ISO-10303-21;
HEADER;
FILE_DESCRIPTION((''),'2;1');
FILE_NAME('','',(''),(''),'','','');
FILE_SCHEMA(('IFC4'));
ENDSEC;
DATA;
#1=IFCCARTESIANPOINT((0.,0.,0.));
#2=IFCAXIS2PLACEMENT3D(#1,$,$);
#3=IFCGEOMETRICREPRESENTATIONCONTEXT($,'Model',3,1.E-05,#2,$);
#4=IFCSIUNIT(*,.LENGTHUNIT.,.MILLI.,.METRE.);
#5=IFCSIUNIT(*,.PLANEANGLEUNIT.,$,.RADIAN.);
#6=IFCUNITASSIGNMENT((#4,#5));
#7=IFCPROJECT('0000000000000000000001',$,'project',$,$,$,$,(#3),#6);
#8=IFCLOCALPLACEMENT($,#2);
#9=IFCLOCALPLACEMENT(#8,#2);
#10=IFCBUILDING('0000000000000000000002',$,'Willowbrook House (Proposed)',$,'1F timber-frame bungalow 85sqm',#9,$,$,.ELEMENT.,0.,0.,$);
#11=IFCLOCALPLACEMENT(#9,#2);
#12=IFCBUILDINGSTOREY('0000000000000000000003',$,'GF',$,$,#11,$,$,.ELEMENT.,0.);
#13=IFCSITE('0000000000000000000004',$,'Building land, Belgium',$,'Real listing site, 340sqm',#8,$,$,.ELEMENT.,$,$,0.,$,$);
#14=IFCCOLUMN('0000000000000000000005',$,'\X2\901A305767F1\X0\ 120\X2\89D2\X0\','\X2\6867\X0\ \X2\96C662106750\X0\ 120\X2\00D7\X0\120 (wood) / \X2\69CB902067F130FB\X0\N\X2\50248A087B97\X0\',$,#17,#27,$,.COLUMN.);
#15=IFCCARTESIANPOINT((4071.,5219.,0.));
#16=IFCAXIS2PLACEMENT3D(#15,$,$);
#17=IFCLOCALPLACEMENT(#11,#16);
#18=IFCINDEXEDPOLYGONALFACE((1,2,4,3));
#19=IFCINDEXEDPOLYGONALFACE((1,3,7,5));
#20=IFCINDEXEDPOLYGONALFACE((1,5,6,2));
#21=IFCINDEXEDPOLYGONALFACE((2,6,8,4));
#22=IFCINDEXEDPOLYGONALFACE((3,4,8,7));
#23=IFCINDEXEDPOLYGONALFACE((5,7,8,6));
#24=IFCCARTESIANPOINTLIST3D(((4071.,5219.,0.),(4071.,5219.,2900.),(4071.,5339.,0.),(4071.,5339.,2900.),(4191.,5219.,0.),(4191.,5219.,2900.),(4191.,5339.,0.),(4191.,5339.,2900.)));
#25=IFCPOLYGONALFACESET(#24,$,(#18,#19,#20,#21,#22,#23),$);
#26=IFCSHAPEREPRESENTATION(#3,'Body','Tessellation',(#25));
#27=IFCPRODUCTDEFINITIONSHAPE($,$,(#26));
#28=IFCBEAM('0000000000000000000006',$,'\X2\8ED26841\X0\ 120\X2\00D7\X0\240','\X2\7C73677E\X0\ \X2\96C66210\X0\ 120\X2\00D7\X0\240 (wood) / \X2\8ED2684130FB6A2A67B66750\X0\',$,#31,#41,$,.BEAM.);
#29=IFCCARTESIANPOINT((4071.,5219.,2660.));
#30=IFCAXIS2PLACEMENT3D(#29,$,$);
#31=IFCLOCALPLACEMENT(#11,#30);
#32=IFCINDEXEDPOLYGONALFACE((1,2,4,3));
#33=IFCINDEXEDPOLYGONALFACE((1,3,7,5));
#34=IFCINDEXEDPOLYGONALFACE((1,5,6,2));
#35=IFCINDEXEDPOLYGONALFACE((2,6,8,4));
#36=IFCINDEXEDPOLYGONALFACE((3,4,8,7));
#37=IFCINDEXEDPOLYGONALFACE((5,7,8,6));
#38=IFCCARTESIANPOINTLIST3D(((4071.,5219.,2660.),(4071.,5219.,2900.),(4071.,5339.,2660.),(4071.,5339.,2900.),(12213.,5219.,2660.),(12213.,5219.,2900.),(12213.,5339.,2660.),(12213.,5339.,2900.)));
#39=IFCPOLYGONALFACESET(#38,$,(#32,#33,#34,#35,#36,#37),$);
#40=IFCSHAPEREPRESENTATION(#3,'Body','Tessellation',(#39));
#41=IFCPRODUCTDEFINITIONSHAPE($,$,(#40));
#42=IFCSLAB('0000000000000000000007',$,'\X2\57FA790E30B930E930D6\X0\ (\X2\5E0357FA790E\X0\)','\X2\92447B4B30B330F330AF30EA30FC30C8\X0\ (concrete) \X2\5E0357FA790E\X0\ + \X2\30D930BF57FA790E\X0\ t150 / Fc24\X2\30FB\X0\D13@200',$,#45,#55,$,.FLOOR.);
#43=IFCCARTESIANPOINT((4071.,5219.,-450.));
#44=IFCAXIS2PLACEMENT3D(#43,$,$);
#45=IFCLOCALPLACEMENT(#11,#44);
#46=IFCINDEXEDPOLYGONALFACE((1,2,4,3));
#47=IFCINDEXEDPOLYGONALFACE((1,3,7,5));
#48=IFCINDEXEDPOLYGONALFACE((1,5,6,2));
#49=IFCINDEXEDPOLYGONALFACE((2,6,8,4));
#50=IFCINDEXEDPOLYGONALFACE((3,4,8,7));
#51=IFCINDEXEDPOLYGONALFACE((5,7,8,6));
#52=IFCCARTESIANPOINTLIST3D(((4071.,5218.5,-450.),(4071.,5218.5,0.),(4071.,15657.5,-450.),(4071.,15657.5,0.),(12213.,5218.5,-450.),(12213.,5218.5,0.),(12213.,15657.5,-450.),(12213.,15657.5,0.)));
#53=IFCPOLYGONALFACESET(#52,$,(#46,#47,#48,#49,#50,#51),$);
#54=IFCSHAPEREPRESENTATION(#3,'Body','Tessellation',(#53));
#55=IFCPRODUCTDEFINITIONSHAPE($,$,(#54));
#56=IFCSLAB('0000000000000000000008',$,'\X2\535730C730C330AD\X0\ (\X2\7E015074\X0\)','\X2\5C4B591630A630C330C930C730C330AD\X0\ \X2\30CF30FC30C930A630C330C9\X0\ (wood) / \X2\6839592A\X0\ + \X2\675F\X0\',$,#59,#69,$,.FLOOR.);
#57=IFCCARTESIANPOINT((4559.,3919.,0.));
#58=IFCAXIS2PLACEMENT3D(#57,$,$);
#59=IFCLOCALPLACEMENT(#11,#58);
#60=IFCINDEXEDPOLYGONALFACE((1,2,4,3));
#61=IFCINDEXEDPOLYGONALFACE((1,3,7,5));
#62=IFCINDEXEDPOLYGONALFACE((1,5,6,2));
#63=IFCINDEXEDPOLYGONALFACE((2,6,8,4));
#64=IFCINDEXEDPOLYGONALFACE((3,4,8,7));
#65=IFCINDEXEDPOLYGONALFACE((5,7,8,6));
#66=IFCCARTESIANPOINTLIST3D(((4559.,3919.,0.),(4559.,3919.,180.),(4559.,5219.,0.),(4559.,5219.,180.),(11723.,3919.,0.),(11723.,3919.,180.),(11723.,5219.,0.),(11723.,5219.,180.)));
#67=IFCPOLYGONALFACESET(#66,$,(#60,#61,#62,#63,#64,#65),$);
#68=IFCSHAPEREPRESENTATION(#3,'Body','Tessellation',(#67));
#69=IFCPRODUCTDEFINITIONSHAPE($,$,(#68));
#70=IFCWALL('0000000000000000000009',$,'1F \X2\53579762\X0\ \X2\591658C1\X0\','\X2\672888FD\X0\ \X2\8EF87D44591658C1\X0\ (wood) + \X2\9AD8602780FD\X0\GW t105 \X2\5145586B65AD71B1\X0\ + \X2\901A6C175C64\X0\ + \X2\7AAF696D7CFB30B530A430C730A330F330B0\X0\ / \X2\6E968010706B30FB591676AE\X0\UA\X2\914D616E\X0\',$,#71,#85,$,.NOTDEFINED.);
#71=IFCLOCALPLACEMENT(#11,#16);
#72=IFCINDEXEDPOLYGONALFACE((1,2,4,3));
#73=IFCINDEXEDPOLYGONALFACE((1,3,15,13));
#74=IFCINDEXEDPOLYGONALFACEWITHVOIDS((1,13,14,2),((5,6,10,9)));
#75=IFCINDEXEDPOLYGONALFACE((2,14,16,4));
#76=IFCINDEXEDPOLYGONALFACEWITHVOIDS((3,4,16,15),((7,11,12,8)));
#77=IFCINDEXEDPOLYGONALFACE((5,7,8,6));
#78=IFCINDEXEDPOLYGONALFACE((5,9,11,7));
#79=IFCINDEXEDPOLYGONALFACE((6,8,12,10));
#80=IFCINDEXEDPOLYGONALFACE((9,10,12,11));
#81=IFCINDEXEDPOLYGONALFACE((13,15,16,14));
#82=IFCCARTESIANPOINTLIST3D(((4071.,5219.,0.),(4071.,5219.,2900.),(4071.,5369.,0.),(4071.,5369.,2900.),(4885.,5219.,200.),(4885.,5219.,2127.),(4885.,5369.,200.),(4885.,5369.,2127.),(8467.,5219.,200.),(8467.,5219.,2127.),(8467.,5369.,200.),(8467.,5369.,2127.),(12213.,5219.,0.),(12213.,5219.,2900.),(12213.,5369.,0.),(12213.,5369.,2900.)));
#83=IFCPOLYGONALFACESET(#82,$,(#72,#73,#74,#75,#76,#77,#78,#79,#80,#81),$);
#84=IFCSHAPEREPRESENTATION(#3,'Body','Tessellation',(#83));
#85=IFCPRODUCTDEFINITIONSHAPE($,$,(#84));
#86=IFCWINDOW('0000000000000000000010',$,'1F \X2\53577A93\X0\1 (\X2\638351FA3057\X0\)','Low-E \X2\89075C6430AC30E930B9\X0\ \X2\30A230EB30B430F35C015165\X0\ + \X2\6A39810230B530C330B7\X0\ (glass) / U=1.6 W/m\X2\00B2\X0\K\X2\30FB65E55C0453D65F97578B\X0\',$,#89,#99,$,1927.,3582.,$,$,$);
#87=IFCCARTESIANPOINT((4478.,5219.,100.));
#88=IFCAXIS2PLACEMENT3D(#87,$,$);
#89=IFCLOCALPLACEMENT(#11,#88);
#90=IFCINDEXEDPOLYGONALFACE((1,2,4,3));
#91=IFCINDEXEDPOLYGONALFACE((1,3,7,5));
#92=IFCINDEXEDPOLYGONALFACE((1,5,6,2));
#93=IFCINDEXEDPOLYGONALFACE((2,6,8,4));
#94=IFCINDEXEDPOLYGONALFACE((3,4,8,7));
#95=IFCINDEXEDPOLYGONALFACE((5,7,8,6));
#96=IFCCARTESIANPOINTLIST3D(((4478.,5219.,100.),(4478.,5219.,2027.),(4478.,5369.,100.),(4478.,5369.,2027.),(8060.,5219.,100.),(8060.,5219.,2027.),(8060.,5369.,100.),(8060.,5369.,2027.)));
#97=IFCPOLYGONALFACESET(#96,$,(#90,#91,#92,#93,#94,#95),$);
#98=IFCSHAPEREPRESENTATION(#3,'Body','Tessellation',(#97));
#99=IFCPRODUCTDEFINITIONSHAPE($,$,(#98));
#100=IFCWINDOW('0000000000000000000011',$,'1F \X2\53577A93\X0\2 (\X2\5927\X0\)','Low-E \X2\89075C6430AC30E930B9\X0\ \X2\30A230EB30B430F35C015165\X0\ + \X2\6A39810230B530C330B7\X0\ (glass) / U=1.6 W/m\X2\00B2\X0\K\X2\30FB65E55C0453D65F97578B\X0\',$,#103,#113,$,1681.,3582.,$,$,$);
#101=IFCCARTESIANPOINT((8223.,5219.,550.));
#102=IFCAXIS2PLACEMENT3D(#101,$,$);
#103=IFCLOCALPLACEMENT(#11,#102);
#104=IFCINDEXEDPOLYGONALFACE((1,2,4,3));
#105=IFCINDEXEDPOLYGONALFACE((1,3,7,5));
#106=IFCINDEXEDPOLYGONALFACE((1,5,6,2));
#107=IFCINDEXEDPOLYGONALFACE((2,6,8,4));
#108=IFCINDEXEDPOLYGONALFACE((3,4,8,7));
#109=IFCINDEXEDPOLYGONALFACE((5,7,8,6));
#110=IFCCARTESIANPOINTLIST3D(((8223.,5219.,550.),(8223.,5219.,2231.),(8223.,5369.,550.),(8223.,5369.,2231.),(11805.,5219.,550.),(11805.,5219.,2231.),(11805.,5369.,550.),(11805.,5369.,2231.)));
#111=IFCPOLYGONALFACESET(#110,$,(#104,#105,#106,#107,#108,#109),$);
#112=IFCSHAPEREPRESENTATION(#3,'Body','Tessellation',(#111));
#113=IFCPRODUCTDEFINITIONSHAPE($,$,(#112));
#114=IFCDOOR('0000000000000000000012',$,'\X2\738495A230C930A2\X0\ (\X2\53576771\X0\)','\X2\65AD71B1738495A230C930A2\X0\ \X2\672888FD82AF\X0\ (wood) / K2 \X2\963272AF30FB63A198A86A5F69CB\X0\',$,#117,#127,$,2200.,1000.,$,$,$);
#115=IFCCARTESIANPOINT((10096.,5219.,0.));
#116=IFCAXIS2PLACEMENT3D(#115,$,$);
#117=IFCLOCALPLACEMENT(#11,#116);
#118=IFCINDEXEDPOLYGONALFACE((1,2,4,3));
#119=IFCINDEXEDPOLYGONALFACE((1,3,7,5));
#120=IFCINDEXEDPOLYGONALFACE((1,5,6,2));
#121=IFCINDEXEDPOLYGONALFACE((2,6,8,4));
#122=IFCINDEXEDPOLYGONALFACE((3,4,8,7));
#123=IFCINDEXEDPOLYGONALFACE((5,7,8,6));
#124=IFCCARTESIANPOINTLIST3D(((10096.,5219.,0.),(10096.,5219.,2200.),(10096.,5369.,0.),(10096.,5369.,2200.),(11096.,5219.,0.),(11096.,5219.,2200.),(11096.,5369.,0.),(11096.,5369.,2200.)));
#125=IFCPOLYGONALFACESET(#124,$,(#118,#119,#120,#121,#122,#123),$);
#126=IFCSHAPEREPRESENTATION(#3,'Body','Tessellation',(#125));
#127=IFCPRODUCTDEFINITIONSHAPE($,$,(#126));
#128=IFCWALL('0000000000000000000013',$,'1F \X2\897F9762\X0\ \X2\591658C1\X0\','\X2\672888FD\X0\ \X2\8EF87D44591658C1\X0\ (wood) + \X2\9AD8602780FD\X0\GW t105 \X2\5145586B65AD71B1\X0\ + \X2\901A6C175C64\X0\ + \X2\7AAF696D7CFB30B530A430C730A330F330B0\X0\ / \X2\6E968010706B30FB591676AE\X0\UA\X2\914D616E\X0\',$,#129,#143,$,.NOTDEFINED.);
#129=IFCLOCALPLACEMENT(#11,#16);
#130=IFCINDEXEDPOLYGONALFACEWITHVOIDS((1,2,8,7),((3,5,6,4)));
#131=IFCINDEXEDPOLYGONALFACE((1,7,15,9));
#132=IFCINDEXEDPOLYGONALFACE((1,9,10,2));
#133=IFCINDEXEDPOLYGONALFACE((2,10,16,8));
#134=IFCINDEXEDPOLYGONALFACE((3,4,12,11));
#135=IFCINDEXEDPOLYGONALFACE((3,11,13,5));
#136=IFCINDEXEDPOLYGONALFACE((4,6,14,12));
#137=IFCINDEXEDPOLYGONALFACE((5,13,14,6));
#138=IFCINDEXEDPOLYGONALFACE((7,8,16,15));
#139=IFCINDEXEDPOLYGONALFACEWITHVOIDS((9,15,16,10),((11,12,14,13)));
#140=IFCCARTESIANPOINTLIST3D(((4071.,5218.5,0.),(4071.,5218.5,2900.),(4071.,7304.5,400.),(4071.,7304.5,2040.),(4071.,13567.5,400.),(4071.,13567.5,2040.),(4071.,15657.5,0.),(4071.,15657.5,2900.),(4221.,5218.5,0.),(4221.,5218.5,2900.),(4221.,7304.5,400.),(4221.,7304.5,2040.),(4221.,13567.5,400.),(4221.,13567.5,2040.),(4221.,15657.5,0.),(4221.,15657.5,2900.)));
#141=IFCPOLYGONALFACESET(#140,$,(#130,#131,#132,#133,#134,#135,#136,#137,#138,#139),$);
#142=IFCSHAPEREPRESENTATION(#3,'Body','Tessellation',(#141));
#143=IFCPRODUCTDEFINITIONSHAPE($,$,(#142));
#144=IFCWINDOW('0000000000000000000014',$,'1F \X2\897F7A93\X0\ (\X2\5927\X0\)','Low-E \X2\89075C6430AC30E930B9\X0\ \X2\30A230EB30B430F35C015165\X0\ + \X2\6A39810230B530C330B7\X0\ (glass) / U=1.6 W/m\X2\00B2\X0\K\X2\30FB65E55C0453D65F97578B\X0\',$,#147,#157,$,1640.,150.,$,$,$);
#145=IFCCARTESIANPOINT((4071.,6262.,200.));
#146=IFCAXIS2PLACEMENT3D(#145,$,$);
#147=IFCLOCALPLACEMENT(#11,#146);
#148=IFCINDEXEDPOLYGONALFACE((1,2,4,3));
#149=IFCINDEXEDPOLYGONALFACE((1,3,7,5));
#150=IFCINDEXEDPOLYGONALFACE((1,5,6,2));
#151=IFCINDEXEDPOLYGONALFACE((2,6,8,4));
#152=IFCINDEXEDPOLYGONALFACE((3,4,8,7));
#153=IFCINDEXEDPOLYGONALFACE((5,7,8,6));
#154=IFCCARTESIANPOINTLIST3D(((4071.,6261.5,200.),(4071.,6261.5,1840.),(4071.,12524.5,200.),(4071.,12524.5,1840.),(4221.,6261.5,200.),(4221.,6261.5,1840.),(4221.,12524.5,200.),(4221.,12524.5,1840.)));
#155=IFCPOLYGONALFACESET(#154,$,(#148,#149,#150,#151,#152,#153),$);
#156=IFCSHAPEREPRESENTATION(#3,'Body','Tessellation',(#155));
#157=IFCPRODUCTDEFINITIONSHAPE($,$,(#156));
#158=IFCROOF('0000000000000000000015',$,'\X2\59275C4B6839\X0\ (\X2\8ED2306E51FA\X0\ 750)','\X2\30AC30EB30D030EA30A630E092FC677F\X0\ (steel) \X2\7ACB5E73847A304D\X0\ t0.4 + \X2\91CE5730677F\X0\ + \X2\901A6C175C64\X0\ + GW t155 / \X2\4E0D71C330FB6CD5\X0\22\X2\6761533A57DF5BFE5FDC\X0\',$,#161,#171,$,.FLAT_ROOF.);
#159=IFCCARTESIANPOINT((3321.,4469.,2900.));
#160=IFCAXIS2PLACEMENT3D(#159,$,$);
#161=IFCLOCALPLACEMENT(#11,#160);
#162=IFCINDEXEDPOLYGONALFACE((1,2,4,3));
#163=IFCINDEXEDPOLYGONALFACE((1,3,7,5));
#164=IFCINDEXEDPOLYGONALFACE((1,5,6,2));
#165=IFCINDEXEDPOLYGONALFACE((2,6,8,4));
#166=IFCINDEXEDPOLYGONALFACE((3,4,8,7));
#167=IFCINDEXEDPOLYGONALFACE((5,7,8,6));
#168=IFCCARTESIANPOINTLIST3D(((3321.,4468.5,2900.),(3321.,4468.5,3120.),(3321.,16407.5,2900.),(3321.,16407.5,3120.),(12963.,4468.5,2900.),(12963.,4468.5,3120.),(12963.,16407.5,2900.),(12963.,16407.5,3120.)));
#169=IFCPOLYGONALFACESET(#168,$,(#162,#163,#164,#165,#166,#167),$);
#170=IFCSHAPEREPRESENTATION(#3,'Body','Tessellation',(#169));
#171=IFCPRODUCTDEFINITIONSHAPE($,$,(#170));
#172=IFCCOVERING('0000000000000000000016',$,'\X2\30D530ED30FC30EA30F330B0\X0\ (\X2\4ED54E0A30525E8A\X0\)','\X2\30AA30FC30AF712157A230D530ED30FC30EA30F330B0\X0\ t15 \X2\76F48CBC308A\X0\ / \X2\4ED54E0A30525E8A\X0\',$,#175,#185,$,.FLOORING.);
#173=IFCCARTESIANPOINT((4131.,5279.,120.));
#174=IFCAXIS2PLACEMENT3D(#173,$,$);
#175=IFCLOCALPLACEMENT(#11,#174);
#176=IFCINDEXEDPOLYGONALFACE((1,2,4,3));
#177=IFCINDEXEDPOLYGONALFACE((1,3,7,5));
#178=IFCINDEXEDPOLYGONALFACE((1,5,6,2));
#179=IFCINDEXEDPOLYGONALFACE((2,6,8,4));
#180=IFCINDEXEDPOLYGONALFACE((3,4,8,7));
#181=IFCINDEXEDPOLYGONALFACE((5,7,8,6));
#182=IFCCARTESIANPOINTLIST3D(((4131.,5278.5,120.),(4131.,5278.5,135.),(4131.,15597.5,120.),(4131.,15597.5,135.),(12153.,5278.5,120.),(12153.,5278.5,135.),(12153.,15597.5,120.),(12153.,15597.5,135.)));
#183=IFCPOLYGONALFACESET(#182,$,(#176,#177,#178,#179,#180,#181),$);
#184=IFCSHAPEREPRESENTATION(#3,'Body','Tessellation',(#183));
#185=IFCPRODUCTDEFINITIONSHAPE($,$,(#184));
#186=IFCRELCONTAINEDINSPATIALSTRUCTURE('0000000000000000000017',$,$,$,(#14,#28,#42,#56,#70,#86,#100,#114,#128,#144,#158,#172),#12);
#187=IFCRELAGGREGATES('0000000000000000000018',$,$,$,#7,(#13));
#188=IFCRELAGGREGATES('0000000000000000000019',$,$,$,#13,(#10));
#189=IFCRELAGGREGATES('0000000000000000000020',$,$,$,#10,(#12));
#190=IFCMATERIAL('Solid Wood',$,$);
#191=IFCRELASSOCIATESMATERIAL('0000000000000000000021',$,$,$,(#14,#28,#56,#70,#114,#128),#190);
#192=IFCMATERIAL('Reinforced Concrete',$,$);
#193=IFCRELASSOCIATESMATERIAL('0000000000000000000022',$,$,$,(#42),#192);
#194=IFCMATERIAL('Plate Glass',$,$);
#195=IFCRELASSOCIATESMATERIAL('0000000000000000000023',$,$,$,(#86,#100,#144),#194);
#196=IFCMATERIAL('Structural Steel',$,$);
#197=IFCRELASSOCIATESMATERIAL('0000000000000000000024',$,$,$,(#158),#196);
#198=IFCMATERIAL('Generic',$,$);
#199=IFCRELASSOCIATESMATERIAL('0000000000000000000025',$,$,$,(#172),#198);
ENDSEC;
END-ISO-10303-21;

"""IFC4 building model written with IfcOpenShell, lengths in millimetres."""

from ifc_helpers import new_model, si_unit, frame, frame_2d, origin, place, context, project, spatial, rectangle, extrude, material, element, fill, save


model = new_model("IFC4")

# Units and contexts
model_context = context("Model", 3, precision=1e-05, world=origin())
ifc_project = project(units=[si_unit("LENGTHUNIT", "METRE", prefix="MILLI"), si_unit("PLANEANGLEUNIT", "RADIAN")], contexts=[model_context])

# Site, building, storey
site_placement = place(None, origin())
site = spatial("IfcSite", under=ifc_project, at=site_placement, Name="Building land, Belgium", ObjectType="Real listing site, 340sqm", CompositionType="ELEMENT", RefElevation=0.0)
building_placement = place(site_placement, origin())
building = spatial("IfcBuilding", under=site, at=building_placement, Name="Willowbrook House (Proposed)", ObjectType="1F timber-frame bungalow 85sqm", CompositionType="ELEMENT", ElevationOfRefHeight=0.0, ElevationOfTerrain=0.0)
storey_placement = place(building_placement, origin())
storey = spatial("IfcBuildingStorey", under=building, at=storey_placement, Name="GF", CompositionType="ELEMENT", Elevation=0.0)

# Column
ifc_material_1 = material(Name="Solid Wood")
column_1_placement = place(storey_placement, frame((4071.0, 5219.0, 0.0)))
element("IfcColumn", 1, at=column_1_placement, inside=storey, material=ifc_material_1, Name="通し柱 120角", Description="桧 集成材 120×120 (wood) / 構造柱・N値計算", PredefinedType="COLUMN", context=model_context, shape_type="SweptSolid", body=[
    extrude(rectangle(XDim=120.0, YDim=120.0, at=frame_2d((60.0, 60.0))), frame((4071.0, 5219.0, 0.0)), (0.0, 0.0, 1.0), 2900.0),
])

# Beam
beam_1_placement = place(storey_placement, frame((4071.0, 5219.0, 2660.0)))
element("IfcBeam", 2, at=beam_1_placement, inside=storey, material=ifc_material_1, Name="軒桁 120×240", Description="米松 集成 120×240 (wood) / 軒桁・横架材", PredefinedType="BEAM", context=model_context, shape_type="SweptSolid", body=[
    extrude(rectangle(XDim=8142.0, YDim=120.0, at=frame_2d((4071.0, 60.0))), frame((4071.0, 5219.0, 2660.0)), (0.0, 0.0, 1.0), 240.0),
])

# Slabs
ifc_material_2 = material(Name="Reinforced Concrete")
slab_1_placement = place(storey_placement, frame((4071.0, 5219.0, -450.0)))
element("IfcSlab", 3, at=slab_1_placement, inside=storey, material=ifc_material_2, Name="基礎スラブ (布基礎)", Description="鉄筋コンクリート (concrete) 布基礎 + ベタ基礎 t150 / Fc24・D13@200", PredefinedType="FLOOR", context=model_context, shape_type="SweptSolid", body=[
    extrude(rectangle(XDim=8142.0, YDim=10439.0, at=frame_2d((4071.0, 5219.0))), frame((4071.0, 5219.0, -450.0)), (0.0, 0.0, 1.0), 450.0),
])
slab_2_placement = place(storey_placement, frame((4559.0, 3919.0, 0.0)))
element("IfcSlab", 4, at=slab_2_placement, inside=storey, material=ifc_material_1, Name="南デッキ (縁側)", Description="屋外ウッドデッキ ハードウッド (wood) / 根太 + 束", PredefinedType="FLOOR", context=model_context, shape_type="SweptSolid", body=[
    extrude(rectangle(XDim=7164.0, YDim=1300.0, at=frame_2d((3582.0, 650.0))), frame((4559.0, 3919.0, 0.0)), (0.0, 0.0, 1.0), 180.0),
])

# Wall, openings, windows, door
wall_1_placement = place(storey_placement, frame((4071.0, 5219.0, 0.0)))
wall_1 = element("IfcWall", 5, at=wall_1_placement, inside=storey, material=ifc_material_1, Name="1F 南面 外壁", Description="木製 軸組外壁 (wood) + 高性能GW t105 充填断熱 + 通気層 + 窯業系サイディング / 準耐火・外皮UA配慮", PredefinedType="NOTDEFINED", context=model_context, shape_type="SweptSolid", body=[
    extrude(rectangle(XDim=8142.0, YDim=150.0, at=frame_2d((4071.0, 75.0))), frame((4071.0, 5219.0, 0.0)), (0.0, 0.0, 1.0), 2900.0),
])
opening_1_placement = place(storey_placement, frame((4478.0, 5219.0, 100.0)))
opening_1 = element("IfcOpeningElement", 6, at=opening_1_placement, cuts=wall_1, PredefinedType="NOTDEFINED", context=model_context, shape_type="SweptSolid", body=[
    extrude(rectangle(XDim=3582.0, YDim=150.0, at=frame_2d((1791.0, 75.0))), frame((4478.0, 5219.0, 100.0)), (0.0, 0.0, 1.0), 1927.0),
])
opening_2_placement = place(storey_placement, frame((8223.0, 5219.0, 550.0)))
opening_2 = element("IfcOpeningElement", 7, at=opening_2_placement, cuts=wall_1, PredefinedType="NOTDEFINED", context=model_context, shape_type="SweptSolid", body=[
    extrude(rectangle(XDim=3582.0, YDim=150.0, at=frame_2d((1791.0, 75.0))), frame((8223.0, 5219.0, 550.0)), (0.0, 0.0, 1.0), 1681.0),
])
opening_3_placement = place(storey_placement, frame((10096.0, 5219.0, 0.0)))
opening_3 = element("IfcOpeningElement", 8, at=opening_3_placement, cuts=wall_1, PredefinedType="NOTDEFINED", context=model_context, shape_type="SweptSolid", body=[
    extrude(rectangle(XDim=1000.0, YDim=150.0, at=frame_2d((500.0, 75.0))), frame((10096.0, 5219.0, 0.0)), (0.0, 0.0, 1.0), 2200.0),
])
ifc_material_3 = material(Name="Plate Glass")
window_1_placement = place(storey_placement, frame((4478.0, 5219.0, 100.0)))
window_1 = element("IfcWindow", 9, at=window_1_placement, inside=storey, material=ifc_material_3, Name="1F 南窓1 (掃出し)", Description="Low-E 複層ガラス アルゴン封入 + 樹脂サッシ (glass) / U=1.6 W/m²K・日射取得型", OverallHeight=1927.0, OverallWidth=3582.0, context=model_context, shape_type="SweptSolid", body=[
    extrude(rectangle(XDim=3582.0, YDim=150.0, at=frame_2d((1791.0, 75.0))), frame((4478.0, 5219.0, 100.0)), (0.0, 0.0, 1.0), 1927.0),
])
fill(opening_1, window_1)
window_2_placement = place(storey_placement, frame((8223.0, 5219.0, 550.0)))
window_2 = element("IfcWindow", 10, at=window_2_placement, inside=storey, material=ifc_material_3, Name="1F 南窓2 (大)", Description="Low-E 複層ガラス アルゴン封入 + 樹脂サッシ (glass) / U=1.6 W/m²K・日射取得型", OverallHeight=1681.0, OverallWidth=3582.0, context=model_context, shape_type="SweptSolid", body=[
    extrude(rectangle(XDim=3582.0, YDim=150.0, at=frame_2d((1791.0, 75.0))), frame((8223.0, 5219.0, 550.0)), (0.0, 0.0, 1.0), 1681.0),
])
fill(opening_2, window_2)
door_placement = place(storey_placement, frame((10096.0, 5219.0, 0.0)))
door = element("IfcDoor", 11, at=door_placement, inside=storey, material=ifc_material_1, Name="玄関ドア (南東)", Description="断熱玄関ドア 木製芯 (wood) / K2 防犯・採風機構", OverallHeight=2200.0, OverallWidth=1000.0, context=model_context, shape_type="SweptSolid", body=[
    extrude(rectangle(XDim=1000.0, YDim=150.0, at=frame_2d((500.0, 75.0))), frame((10096.0, 5219.0, 0.0)), (0.0, 0.0, 1.0), 2200.0),
])
fill(opening_3, door)

# Wall, opening, window
wall_2_placement = place(storey_placement, frame((4071.0, 5219.0, 0.0)))
wall_2 = element("IfcWall", 12, at=wall_2_placement, inside=storey, material=ifc_material_1, Name="1F 西面 外壁", Description="木製 軸組外壁 (wood) + 高性能GW t105 充填断熱 + 通気層 + 窯業系サイディング / 準耐火・外皮UA配慮", PredefinedType="NOTDEFINED", context=model_context, shape_type="SweptSolid", body=[
    extrude(rectangle(XDim=150.0, YDim=10439.0, at=frame_2d((75.0, 5219.0))), frame((4071.0, 5219.0, 0.0)), (0.0, 0.0, 1.0), 2900.0),
])
opening_4_placement = place(storey_placement, frame((4071.0, 6262.0, 200.0)))
opening_4 = element("IfcOpeningElement", 13, at=opening_4_placement, cuts=wall_2, PredefinedType="NOTDEFINED", context=model_context, shape_type="SweptSolid", body=[
    extrude(rectangle(XDim=150.0, YDim=6263.0, at=frame_2d((75.0, 3131.0))), frame((4071.0, 6262.0, 200.0)), (0.0, 0.0, 1.0), 1640.0),
])
window_3_placement = place(storey_placement, frame((4071.0, 6262.0, 200.0)))
window_3 = element("IfcWindow", 14, at=window_3_placement, inside=storey, material=ifc_material_3, Name="1F 西窓 (大)", Description="Low-E 複層ガラス アルゴン封入 + 樹脂サッシ (glass) / U=1.6 W/m²K・日射取得型", OverallHeight=1640.0, OverallWidth=150.0, context=model_context, shape_type="SweptSolid", body=[
    extrude(rectangle(XDim=150.0, YDim=6263.0, at=frame_2d((75.0, 3131.0))), frame((4071.0, 6262.0, 200.0)), (0.0, 0.0, 1.0), 1640.0),
])
fill(opening_4, window_3)

# Roof
ifc_material_4 = material(Name="Structural Steel")
roof_placement = place(storey_placement, frame((3321.0, 4469.0, 2900.0)))
element("IfcRoof", 15, at=roof_placement, inside=storey, material=ifc_material_4, Name="大屋根 (軒の出 750)", Description="ガルバリウム鋼板 (steel) 立平葺き t0.4 + 野地板 + 通気層 + GW t155 / 不燃・法22条区域対応", PredefinedType="FLAT_ROOF", context=model_context, shape_type="SweptSolid", body=[
    extrude(rectangle(XDim=9642.0, YDim=11939.0, at=frame_2d((4821.0, 5969.0))), frame((3321.0, 4469.0, 2900.0)), (0.0, 0.0, 1.0), 220.0),
])

# Covering
ifc_material_5 = material(Name="Generic")
covering_1_placement = place(storey_placement, frame((4131.0, 5279.0, 120.0)))
element("IfcCovering", 16, at=covering_1_placement, inside=storey, material=ifc_material_5, Name="フローリング (仕上げ床)", Description="オーク無垢フローリング t15 直貼り / 仕上げ床", PredefinedType="FLOORING", context=model_context, shape_type="SweptSolid", body=[
    extrude(rectangle(XDim=8022.0, YDim=10319.0, at=frame_2d((4011.0, 5159.0))), frame((4131.0, 5279.0, 120.0)), (0.0, 0.0, 1.0), 15.0),
])

save(model, "model.ifc")
